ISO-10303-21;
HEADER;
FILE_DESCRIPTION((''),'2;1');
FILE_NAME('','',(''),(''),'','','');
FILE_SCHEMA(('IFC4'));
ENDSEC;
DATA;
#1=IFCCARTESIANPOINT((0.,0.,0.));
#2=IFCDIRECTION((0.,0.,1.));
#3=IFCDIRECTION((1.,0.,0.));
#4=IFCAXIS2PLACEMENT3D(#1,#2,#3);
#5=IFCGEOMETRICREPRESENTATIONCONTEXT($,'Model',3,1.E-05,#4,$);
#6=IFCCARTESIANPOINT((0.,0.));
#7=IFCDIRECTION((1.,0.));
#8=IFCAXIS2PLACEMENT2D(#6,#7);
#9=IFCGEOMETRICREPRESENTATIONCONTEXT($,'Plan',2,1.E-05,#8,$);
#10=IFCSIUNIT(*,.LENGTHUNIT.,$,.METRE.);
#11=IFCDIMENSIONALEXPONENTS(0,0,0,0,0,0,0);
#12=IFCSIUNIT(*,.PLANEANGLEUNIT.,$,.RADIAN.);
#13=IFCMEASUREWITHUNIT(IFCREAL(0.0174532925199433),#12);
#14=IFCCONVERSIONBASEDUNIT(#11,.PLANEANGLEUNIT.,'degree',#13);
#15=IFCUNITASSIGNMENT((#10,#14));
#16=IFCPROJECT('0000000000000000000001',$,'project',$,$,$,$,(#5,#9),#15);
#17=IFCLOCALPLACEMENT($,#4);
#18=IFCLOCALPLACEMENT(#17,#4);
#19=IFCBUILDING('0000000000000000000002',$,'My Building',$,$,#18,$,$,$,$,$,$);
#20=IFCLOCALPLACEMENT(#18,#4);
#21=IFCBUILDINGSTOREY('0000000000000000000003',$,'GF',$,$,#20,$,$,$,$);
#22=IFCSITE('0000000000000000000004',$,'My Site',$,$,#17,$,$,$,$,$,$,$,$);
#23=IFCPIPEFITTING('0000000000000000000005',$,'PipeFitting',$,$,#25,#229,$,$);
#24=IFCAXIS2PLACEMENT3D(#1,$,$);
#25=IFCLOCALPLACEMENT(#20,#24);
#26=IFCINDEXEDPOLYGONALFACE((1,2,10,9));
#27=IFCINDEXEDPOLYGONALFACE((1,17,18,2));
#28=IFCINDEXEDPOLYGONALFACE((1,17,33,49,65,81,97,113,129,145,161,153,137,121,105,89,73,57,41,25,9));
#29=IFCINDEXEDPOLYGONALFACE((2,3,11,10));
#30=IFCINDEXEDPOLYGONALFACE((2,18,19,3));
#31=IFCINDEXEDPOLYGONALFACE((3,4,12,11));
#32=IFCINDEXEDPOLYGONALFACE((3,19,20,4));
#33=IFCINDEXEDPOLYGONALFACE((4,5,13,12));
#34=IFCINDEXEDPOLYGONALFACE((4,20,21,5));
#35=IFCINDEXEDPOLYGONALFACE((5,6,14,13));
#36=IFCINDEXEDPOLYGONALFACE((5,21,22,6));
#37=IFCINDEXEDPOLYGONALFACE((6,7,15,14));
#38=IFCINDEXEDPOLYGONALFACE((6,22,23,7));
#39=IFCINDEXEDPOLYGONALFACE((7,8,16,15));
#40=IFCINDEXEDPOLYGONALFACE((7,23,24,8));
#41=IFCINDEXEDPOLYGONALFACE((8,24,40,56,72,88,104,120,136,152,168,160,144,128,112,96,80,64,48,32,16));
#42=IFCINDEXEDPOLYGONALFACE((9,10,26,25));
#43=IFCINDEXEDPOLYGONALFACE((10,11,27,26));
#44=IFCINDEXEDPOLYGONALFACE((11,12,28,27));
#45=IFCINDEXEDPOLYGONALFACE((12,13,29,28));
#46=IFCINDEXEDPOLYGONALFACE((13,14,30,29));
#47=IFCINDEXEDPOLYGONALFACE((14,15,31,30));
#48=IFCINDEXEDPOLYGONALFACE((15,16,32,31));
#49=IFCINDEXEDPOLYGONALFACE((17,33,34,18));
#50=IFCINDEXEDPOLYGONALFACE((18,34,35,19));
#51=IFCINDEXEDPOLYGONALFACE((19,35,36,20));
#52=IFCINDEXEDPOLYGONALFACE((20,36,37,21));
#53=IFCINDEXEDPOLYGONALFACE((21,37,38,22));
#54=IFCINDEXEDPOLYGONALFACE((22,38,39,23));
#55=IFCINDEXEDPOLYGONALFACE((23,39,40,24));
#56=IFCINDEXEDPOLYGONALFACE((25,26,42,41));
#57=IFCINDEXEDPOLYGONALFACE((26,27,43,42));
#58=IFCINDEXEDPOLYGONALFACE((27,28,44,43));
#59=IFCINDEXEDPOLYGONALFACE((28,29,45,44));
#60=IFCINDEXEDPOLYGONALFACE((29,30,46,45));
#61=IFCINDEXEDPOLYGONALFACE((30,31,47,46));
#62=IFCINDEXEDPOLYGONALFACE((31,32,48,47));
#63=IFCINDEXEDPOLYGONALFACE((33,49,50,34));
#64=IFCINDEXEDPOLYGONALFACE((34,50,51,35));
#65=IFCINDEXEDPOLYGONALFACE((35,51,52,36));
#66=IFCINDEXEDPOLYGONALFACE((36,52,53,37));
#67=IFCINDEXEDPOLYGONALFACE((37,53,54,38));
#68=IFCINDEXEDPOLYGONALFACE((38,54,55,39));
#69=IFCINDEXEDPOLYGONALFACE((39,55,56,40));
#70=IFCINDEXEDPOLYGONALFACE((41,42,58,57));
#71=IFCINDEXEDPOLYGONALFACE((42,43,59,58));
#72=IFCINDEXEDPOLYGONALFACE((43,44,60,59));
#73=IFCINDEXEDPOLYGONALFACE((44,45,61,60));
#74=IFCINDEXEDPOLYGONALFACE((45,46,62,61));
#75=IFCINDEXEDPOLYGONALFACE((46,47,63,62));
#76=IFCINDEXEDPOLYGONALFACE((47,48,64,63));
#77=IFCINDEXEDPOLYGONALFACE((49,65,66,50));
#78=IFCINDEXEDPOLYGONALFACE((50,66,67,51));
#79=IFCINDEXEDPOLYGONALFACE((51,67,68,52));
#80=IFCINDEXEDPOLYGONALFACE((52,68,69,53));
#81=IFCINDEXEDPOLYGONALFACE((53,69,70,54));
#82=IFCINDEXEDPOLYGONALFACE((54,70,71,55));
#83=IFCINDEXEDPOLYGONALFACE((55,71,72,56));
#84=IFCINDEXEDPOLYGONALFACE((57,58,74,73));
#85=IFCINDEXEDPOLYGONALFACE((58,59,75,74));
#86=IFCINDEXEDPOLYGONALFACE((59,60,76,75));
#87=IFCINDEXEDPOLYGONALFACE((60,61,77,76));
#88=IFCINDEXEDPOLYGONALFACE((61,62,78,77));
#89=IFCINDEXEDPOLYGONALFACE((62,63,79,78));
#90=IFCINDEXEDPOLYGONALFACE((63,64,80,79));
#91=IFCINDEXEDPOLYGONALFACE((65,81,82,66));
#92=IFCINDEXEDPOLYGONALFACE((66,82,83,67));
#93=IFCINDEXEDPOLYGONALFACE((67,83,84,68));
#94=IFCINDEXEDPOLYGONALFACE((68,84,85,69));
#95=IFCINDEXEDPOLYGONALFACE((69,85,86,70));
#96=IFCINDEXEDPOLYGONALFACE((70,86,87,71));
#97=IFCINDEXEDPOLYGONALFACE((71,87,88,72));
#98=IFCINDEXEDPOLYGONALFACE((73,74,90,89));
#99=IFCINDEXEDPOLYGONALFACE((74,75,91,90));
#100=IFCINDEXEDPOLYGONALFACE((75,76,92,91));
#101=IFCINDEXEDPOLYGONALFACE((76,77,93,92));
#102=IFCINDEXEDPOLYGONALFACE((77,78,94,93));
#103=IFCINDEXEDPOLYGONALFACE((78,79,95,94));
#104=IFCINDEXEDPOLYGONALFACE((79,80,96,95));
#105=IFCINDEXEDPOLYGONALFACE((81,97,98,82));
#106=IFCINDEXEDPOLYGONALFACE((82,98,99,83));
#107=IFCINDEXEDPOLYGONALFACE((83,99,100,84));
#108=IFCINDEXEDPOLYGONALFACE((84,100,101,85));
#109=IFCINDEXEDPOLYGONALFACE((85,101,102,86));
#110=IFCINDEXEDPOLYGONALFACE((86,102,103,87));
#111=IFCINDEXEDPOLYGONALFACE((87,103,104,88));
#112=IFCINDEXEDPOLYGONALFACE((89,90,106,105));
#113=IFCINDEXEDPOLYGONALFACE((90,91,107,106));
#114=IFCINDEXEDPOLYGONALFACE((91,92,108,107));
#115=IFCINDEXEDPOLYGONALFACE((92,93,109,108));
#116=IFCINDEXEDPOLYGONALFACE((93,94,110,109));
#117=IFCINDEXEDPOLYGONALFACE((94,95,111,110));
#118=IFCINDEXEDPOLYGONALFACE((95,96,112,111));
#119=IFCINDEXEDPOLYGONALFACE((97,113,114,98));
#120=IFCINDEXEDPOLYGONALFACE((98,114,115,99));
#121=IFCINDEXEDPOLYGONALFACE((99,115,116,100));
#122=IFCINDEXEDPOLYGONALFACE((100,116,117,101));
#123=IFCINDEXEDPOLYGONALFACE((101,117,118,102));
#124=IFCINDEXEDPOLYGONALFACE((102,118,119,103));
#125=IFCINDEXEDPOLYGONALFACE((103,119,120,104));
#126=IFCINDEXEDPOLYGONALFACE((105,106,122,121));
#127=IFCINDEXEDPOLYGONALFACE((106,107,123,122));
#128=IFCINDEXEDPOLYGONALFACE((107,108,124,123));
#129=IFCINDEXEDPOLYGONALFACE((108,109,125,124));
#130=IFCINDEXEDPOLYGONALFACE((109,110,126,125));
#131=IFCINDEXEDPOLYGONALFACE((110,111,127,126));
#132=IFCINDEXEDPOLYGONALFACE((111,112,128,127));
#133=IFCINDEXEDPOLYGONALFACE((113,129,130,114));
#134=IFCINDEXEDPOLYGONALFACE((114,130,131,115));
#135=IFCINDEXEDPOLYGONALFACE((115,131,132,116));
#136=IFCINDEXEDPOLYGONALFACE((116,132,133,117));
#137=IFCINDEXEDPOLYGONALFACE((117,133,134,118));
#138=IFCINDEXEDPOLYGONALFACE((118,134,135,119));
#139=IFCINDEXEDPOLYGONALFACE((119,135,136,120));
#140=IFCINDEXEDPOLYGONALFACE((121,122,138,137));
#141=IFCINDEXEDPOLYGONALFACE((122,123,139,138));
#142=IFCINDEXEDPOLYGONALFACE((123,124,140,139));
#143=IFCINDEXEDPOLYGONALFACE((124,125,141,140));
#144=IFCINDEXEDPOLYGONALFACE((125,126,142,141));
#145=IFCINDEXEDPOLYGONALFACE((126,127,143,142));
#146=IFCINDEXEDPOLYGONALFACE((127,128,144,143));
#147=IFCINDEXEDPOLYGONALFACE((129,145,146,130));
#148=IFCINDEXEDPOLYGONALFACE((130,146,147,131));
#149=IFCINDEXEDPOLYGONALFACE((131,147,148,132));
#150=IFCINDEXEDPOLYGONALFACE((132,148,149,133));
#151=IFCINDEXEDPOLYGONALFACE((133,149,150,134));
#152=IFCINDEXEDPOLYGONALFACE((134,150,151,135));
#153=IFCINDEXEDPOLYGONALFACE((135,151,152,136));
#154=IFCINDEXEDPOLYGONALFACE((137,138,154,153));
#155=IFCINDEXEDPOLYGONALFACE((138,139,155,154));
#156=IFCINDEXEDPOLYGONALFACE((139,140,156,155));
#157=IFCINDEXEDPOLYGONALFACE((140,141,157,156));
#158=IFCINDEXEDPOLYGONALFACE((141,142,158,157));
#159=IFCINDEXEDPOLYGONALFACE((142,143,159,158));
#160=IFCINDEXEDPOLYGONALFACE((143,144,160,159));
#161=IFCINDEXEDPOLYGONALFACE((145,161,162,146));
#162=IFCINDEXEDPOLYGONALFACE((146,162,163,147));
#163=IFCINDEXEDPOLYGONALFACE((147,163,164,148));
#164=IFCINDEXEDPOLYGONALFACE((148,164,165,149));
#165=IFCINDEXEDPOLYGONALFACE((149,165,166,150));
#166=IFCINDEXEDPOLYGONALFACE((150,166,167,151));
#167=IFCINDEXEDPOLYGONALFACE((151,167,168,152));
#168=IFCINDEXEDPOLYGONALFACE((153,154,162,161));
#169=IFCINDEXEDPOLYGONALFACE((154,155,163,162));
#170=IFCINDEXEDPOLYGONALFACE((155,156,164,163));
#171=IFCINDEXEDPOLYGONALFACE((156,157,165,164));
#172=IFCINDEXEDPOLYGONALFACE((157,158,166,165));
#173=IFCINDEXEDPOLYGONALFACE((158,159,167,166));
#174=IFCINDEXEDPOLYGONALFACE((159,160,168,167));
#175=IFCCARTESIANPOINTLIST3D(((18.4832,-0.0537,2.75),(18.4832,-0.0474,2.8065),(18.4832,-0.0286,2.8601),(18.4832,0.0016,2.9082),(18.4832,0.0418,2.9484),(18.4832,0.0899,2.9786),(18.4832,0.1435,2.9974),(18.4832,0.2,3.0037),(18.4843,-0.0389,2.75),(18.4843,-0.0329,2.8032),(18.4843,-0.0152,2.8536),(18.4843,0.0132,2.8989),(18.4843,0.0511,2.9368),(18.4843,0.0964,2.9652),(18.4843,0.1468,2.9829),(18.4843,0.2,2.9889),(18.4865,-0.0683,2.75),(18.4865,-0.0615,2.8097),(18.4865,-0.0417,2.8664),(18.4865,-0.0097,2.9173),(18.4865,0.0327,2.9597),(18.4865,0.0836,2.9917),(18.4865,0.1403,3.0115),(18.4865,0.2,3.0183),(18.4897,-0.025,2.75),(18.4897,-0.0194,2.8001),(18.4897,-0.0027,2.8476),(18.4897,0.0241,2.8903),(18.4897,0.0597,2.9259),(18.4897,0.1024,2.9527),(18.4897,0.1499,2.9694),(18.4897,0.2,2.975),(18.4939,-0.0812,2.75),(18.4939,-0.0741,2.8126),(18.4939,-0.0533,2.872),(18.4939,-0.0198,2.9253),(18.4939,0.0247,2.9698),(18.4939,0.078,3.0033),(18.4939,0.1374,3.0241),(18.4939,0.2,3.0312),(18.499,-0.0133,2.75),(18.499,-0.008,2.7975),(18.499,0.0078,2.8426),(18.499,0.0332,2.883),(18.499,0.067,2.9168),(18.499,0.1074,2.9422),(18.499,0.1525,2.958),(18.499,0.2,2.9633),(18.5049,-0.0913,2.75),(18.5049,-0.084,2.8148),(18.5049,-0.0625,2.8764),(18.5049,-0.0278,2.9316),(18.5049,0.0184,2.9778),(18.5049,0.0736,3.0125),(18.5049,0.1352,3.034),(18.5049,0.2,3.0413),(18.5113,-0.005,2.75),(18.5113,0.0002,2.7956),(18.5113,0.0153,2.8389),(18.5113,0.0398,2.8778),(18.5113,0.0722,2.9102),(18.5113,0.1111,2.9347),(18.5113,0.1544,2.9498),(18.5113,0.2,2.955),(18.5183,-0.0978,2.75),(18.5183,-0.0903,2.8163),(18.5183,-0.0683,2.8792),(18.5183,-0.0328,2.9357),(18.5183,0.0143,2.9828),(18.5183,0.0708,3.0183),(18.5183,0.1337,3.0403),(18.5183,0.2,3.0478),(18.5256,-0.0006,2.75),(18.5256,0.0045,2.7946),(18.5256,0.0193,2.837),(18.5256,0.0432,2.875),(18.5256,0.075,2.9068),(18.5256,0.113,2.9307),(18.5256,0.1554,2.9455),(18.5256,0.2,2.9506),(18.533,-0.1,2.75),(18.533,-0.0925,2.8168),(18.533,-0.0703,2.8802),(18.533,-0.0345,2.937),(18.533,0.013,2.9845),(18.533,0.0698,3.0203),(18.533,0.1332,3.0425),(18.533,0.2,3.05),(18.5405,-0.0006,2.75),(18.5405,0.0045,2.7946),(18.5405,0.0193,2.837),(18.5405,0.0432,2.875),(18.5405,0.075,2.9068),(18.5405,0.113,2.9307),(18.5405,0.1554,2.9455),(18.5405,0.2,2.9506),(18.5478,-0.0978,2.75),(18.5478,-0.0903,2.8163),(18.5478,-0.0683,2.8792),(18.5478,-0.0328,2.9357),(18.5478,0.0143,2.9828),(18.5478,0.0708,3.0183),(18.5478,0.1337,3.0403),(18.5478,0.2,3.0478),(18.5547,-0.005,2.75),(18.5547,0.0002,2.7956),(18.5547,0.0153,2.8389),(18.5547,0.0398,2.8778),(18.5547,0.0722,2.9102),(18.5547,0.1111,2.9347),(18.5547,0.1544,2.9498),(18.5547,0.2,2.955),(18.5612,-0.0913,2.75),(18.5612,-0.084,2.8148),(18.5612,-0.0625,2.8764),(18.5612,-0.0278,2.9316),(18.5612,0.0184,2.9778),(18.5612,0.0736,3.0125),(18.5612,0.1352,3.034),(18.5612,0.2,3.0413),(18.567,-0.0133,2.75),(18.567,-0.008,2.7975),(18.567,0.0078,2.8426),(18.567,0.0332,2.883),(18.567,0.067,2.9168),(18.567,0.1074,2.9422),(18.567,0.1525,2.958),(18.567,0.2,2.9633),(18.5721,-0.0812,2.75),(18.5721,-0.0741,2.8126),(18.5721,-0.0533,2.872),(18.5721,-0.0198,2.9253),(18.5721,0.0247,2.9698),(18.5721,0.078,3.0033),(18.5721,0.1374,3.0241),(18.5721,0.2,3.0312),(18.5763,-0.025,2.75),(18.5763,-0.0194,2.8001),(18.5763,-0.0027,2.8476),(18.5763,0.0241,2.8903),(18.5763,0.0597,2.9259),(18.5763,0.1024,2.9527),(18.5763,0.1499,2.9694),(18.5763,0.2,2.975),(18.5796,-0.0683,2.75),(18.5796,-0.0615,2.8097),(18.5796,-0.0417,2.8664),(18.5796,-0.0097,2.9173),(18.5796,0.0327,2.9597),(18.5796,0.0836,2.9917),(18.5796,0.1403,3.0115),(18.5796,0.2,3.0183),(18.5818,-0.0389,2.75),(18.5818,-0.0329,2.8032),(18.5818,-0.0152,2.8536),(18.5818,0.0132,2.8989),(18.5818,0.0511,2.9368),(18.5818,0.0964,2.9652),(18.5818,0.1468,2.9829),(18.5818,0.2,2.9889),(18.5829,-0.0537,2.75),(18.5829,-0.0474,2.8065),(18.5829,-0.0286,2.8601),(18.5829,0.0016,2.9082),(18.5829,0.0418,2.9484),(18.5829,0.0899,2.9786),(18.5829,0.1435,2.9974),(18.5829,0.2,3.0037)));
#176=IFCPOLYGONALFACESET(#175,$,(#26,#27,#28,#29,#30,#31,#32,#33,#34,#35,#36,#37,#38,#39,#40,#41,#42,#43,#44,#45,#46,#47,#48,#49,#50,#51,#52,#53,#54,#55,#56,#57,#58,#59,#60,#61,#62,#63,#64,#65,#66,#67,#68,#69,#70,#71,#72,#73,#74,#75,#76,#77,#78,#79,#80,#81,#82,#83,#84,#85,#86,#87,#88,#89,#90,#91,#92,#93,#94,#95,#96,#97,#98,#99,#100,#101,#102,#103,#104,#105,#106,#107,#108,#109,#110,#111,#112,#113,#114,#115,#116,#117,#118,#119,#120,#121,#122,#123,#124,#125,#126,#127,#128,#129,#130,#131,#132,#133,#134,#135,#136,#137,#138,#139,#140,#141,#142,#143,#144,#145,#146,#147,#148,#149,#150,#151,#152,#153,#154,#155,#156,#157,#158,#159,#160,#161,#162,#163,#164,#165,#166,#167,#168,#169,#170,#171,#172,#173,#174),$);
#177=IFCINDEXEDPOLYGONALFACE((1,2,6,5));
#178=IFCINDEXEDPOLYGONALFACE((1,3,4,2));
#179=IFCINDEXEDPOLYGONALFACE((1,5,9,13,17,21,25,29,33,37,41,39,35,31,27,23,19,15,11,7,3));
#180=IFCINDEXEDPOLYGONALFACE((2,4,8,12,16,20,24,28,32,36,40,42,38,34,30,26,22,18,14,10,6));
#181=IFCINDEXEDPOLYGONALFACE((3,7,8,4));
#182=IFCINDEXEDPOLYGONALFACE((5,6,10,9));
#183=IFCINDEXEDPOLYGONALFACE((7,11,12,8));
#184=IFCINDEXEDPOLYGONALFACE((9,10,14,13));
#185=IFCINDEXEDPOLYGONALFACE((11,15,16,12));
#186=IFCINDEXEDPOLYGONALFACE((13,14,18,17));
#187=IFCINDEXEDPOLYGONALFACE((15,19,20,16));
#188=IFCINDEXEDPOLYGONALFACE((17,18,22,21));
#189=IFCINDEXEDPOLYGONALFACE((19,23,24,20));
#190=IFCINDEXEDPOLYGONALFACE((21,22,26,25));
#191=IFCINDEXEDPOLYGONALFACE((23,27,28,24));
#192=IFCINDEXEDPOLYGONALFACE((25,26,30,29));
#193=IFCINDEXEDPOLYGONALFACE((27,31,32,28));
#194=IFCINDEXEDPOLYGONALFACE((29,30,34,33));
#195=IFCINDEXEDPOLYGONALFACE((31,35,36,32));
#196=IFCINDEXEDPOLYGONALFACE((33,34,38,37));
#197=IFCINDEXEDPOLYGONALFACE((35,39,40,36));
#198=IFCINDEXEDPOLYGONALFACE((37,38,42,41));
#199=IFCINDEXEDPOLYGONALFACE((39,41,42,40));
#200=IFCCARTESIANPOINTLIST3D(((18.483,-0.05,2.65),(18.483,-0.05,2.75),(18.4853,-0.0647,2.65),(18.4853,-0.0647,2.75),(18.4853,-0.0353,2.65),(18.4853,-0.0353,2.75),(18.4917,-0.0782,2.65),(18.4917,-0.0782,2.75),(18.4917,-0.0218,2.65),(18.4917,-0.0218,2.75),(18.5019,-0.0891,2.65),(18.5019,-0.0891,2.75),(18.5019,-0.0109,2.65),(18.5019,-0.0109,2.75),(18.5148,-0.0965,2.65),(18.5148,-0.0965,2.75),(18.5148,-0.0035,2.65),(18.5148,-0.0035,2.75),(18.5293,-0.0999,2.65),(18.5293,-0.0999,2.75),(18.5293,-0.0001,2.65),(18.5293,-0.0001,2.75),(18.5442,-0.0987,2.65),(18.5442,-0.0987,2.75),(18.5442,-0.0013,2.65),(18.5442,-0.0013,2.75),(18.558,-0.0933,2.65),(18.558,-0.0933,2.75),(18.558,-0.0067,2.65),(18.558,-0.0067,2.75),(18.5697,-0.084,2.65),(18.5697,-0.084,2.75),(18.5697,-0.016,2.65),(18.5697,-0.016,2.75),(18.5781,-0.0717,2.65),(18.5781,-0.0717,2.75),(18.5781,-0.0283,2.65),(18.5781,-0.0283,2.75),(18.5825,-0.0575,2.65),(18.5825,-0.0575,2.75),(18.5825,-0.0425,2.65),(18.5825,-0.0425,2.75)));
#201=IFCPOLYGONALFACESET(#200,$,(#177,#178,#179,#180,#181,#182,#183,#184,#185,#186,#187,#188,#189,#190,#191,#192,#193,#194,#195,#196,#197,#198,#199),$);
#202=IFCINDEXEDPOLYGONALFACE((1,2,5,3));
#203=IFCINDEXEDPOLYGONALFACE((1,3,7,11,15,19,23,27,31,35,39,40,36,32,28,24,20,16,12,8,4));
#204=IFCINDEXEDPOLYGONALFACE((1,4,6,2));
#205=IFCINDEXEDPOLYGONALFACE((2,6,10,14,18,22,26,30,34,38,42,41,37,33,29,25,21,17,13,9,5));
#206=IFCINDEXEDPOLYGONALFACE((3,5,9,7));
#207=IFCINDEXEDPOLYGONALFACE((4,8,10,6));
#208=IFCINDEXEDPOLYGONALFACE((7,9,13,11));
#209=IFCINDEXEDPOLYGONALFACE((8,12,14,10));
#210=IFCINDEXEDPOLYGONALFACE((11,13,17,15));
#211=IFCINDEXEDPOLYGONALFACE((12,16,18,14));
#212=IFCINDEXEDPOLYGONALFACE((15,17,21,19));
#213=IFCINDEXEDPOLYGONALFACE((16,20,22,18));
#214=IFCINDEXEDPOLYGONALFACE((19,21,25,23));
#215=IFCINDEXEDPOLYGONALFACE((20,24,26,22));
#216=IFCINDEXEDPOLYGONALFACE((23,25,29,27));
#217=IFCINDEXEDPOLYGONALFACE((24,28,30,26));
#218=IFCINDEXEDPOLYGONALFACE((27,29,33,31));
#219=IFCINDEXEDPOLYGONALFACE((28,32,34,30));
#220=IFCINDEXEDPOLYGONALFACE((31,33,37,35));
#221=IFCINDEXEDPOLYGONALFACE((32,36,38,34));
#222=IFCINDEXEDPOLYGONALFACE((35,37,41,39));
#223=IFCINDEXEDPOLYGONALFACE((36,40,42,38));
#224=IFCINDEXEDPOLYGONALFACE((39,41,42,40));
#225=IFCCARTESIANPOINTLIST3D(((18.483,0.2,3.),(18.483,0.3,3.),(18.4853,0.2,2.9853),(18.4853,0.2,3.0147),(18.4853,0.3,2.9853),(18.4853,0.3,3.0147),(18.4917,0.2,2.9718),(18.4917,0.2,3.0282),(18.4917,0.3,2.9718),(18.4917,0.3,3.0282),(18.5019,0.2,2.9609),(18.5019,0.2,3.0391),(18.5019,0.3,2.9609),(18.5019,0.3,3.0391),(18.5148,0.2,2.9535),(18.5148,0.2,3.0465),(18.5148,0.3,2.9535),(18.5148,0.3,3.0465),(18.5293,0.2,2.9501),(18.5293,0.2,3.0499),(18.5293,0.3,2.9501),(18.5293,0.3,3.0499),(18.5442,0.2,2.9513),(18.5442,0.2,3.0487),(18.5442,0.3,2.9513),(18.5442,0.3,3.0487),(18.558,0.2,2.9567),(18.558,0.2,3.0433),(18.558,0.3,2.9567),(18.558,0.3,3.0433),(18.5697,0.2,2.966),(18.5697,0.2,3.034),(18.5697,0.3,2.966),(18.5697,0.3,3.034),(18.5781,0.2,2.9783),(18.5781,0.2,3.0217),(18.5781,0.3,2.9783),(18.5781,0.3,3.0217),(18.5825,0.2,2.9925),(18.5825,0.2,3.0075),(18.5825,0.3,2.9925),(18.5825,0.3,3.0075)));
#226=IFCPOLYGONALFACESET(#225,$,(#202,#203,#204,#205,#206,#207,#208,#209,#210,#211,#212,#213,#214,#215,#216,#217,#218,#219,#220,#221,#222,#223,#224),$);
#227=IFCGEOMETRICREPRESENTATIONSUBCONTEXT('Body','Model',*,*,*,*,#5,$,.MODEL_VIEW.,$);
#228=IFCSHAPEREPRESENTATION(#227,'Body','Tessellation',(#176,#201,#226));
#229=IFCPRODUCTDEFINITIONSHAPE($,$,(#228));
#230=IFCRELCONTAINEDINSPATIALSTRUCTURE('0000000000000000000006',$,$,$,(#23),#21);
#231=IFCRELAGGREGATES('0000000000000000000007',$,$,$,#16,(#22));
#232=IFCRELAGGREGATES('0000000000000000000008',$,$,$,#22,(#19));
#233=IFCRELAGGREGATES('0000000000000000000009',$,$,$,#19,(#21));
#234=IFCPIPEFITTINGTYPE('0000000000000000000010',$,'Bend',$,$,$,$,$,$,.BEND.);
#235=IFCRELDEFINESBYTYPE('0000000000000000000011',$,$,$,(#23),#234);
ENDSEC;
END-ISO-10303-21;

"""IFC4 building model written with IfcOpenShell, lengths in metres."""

from ifc_helpers import new_model, entity, si_unit, converted_unit, frame, origin_with_axes, origin_2d_with_axis, place, context, subcontext, project, spatial, circle, extrude, source, transform, mapped, type_object, type_shapes, element, save


model = new_model("IFC4")

# Units and contexts
model_context = context("Model", 3, precision=1e-05, world=origin_with_axes())
plan_context = context("Plan", 2, precision=1e-05, world=origin_2d_with_axis())
body_context_1 = subcontext(model_context, "Body", "Model", "MODEL_VIEW")
ifc_project = project(units=[si_unit("LENGTHUNIT", "METRE"), converted_unit("PLANEANGLEUNIT", "degree", entity("IfcReal", 0.0174532925199433), si_unit("PLANEANGLEUNIT", "RADIAN"), dimensions=[0, 0, 0, 0, 0, 0, 0])], contexts=[model_context, plan_context])

# Site, building, storey
site_placement = place(None, origin_with_axes())
site = spatial("IfcSite", under=ifc_project, at=site_placement, Name="My Site")
building_placement = place(site_placement, origin_with_axes())
building = spatial("IfcBuilding", under=site, at=building_placement, Name="My Building")
storey_placement = place(building_placement, origin_with_axes())
storey = spatial("IfcBuildingStorey", under=building, at=storey_placement, Name="GF")

# Pipe fitting
pipe_fitting_type = type_object("IfcPipeFittingType", Name="Bend", PredefinedType="BEND")
shared_shape_1 = source(origin_with_axes(), body_context_1, "Body", "SolidModel", [
    entity("IfcSweptDiskSolid", entity("IfcIndexedPolyCurve", entity("IfcCartesianPointList3D", [[0.0, 0.0, 0.1], [0.0, -0.0732, 0.2768], [0.0, -0.25, 0.35]]), [entity("IfcArcIndex", [1, 2, 3])]), 0.05),
    extrude(circle(Radius=0.05), origin_with_axes(), (0.0, 0.0, 1.0), 0.1),
    extrude(circle(Radius=0.05), frame((0.0, -0.25, 0.35), z_axis=(0.0, -1.0, 0.0), x_axis=(1.0, 0.0, 0.0)), (0.0, 0.0, 1.0), 0.1),
])
type_shapes(pipe_fitting_type, [shared_shape_1])
for number, where, z_axis, x_axis, name in (
    (1, (18.533, -0.05, 2.65), (-0.000004, 0.0, 1.0), (-1.0, 0.0, -0.000004), "PipeFitting"),
):
    element("IfcPipeFitting", number, at=place(storey_placement, frame(where, z_axis=z_axis, x_axis=x_axis)), inside=storey, type_object=pipe_fitting_type, Name=name, context=body_context_1, shape_type="MappedRepresentation", body=[
        mapped(shared_shape_1, transform((0.0, 0.0, 0.0), x_axis=(1.0, 0.0, 0.0), y_axis=(0.0, 1.0, 0.0), z_axis=(0.0, 0.0, 1.0), scale=1.0)),
    ])

save(model, "model.ifc")
